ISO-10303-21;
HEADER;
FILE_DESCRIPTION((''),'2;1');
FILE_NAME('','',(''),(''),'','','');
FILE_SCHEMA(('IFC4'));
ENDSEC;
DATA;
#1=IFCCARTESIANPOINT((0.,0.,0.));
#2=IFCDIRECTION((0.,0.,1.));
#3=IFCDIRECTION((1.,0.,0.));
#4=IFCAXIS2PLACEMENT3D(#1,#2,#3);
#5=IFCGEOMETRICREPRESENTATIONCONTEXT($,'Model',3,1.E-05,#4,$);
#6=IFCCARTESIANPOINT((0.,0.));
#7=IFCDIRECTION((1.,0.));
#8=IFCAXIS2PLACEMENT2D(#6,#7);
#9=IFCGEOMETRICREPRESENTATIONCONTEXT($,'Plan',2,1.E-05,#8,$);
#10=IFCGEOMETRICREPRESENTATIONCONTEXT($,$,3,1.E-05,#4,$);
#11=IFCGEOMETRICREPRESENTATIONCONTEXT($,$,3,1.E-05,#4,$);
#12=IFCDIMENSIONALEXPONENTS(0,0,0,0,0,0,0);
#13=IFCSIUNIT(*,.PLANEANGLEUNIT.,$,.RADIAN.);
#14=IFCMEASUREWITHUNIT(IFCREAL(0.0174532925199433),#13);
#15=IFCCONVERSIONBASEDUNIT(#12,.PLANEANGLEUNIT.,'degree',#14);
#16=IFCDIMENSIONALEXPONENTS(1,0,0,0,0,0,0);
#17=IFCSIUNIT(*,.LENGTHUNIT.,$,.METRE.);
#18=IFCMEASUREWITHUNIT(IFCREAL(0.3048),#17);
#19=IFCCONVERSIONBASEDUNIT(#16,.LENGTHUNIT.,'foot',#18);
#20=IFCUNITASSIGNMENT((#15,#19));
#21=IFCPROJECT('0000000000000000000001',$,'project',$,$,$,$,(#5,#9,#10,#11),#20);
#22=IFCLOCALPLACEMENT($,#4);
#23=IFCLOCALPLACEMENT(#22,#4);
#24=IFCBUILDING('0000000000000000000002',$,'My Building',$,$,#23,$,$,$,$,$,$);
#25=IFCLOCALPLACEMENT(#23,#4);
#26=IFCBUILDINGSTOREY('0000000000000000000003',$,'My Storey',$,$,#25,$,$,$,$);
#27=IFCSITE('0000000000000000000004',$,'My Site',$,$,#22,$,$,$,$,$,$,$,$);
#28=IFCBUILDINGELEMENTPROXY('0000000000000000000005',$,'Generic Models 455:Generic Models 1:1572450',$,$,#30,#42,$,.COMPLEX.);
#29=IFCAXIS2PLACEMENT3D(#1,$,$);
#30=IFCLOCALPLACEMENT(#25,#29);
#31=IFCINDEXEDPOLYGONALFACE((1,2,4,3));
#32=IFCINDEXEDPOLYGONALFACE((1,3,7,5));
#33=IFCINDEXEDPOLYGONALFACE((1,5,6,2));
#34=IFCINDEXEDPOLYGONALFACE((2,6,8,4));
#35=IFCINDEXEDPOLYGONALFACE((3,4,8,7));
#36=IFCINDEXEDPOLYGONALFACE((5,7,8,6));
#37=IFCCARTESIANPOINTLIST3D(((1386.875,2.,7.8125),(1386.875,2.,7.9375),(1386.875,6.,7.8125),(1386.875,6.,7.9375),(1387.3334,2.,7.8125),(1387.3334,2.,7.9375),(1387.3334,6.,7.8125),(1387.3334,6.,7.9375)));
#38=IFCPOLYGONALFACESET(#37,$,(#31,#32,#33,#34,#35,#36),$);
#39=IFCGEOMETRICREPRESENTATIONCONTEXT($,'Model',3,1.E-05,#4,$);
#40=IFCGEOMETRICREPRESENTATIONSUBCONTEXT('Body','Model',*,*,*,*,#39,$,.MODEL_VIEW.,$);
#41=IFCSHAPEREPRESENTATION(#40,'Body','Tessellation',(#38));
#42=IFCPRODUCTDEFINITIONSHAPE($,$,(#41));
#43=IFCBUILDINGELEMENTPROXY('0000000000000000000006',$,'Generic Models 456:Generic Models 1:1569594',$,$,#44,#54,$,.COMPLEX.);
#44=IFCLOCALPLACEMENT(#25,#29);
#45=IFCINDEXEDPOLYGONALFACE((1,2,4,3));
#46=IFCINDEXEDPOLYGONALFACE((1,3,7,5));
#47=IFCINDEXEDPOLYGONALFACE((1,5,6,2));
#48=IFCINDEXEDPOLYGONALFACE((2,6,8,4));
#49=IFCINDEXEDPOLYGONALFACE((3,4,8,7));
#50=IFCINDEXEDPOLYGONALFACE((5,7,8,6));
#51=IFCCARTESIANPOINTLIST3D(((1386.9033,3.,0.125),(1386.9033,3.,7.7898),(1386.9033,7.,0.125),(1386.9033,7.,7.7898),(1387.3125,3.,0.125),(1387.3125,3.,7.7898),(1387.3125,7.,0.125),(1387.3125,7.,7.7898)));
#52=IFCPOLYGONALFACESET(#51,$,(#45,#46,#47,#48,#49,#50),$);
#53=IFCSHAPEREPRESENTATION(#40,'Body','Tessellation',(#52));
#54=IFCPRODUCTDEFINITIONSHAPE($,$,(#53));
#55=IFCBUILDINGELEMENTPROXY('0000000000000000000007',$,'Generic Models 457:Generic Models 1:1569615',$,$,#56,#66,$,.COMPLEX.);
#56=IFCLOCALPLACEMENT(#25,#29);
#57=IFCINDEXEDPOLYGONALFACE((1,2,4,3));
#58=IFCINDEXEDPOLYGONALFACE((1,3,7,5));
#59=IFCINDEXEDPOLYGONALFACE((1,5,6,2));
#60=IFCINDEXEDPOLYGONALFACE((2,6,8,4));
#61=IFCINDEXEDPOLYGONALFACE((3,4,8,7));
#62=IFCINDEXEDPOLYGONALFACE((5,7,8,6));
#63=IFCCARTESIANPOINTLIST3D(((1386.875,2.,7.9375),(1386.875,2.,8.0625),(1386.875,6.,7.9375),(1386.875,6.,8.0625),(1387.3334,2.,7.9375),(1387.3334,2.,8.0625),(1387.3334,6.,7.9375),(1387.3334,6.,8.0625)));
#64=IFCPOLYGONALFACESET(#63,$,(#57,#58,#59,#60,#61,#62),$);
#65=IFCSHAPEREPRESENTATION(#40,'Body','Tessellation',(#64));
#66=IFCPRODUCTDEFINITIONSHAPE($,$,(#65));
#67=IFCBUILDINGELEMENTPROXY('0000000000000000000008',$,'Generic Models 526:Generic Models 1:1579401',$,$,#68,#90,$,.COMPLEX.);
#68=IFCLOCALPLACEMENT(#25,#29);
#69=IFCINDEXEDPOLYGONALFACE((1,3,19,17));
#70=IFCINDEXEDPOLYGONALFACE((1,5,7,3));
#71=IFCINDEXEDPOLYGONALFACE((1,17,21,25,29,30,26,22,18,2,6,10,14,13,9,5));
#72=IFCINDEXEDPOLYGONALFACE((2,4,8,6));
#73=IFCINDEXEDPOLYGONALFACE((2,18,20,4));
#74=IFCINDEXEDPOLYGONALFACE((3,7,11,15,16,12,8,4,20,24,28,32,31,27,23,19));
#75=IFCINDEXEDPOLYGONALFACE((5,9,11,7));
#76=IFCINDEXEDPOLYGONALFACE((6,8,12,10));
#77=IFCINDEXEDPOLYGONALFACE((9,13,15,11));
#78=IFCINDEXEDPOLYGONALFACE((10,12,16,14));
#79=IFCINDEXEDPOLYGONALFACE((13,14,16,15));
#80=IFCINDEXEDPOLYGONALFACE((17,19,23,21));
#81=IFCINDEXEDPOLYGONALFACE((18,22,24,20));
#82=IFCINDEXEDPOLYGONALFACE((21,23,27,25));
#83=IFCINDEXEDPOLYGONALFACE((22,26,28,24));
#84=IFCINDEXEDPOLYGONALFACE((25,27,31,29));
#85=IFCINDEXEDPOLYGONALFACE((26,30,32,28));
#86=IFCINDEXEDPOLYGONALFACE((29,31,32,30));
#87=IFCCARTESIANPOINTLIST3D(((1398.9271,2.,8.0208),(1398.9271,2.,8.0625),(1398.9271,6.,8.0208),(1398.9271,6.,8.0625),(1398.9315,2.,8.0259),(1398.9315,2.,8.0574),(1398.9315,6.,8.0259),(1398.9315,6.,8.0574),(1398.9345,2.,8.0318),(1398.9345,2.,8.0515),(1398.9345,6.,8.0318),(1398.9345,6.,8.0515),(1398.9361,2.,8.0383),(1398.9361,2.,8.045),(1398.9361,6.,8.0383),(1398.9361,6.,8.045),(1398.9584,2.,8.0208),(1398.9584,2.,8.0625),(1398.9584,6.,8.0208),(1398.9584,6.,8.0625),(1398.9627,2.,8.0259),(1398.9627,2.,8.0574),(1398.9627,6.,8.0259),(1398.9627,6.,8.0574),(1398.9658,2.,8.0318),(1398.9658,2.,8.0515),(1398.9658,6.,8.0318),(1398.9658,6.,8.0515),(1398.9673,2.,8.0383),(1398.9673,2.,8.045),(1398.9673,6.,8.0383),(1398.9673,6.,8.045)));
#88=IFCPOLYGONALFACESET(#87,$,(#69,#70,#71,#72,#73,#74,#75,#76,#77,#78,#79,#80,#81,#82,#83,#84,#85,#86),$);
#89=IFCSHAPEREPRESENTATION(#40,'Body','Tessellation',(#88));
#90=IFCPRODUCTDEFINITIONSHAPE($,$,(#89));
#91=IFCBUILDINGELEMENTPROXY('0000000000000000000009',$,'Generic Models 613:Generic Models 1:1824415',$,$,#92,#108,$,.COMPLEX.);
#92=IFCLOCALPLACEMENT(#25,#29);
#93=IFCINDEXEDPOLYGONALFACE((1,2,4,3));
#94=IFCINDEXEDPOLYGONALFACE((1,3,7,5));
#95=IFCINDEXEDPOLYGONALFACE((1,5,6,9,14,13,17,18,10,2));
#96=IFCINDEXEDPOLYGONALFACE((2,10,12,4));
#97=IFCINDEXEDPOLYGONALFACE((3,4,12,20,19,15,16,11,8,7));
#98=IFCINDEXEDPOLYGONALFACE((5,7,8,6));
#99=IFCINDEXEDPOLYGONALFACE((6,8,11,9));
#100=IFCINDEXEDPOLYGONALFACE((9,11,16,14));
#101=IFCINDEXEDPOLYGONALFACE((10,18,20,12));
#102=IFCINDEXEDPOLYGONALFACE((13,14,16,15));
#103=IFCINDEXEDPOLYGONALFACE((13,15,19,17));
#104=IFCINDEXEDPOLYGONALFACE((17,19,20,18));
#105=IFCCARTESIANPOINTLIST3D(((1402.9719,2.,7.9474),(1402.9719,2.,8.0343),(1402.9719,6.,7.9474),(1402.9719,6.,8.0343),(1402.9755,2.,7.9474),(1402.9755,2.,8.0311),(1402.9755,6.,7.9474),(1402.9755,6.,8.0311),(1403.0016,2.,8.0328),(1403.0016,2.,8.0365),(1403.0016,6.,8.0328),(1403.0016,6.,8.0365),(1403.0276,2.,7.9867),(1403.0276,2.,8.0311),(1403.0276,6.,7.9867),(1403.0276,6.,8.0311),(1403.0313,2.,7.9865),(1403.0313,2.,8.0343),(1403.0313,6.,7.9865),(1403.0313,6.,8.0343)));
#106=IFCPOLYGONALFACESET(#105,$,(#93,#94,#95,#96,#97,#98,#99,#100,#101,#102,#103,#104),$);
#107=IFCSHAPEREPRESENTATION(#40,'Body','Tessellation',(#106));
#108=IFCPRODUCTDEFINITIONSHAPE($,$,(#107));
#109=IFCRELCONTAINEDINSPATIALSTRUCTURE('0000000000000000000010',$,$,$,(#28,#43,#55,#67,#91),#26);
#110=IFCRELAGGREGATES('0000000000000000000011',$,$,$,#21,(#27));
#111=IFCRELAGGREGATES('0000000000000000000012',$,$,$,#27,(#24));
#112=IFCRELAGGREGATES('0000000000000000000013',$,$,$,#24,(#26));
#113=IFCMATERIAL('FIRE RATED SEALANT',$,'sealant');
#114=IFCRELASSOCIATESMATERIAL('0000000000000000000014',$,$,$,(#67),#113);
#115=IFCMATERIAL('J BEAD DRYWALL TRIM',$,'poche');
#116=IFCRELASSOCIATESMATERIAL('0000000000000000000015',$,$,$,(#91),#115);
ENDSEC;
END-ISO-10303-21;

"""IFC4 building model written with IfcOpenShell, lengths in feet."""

from ifc_helpers import new_model, entity, si_unit, converted_unit, frame, origin_with_axes, origin_2d_with_axis, place, context, subcontext, project, spatial, polyline, line, indexed_curve, outline, extrude, material, element, save


model = new_model("IFC4")

# Units and contexts
model_context_1 = context("Model", 3, precision=1e-05, world=origin_with_axes())
plan_context = context("Plan", 2, precision=1e-05, world=origin_2d_with_axis())
model_context_2 = context("Model", 3, precision=1e-05, world=origin_with_axes())
context_of_model_1 = context(None, 3, precision=1e-05, world=origin_with_axes())
context_of_model_2 = context(None, 3, precision=1e-05, world=origin_with_axes())
body_context = subcontext(model_context_2, "Body", "Model", "MODEL_VIEW")
ifc_project = project(units=[converted_unit("PLANEANGLEUNIT", "degree", entity("IfcReal", 0.0174532925199433), si_unit("PLANEANGLEUNIT", "RADIAN"), dimensions=[0, 0, 0, 0, 0, 0, 0]), converted_unit("LENGTHUNIT", "foot", entity("IfcReal", 0.3048), si_unit("LENGTHUNIT", "METRE"), dimensions=[1, 0, 0, 0, 0, 0, 0])], contexts=[model_context_1, plan_context, context_of_model_1, context_of_model_2])

# Site, building, storey
site_placement = place(None, origin_with_axes())
site = spatial("IfcSite", under=ifc_project, at=site_placement, Name="My Site")
building_placement = place(site_placement, origin_with_axes())
building = spatial("IfcBuilding", under=site, at=building_placement, Name="My Building")
storey_placement = place(building_placement, origin_with_axes())
storey = spatial("IfcBuildingStorey", under=building, at=storey_placement, Name="My Storey")

# Building element proxies
ifc_material_1 = material(Name="FIRE RATED SEALANT", Category="sealant")
proxy_1_placement = place(storey_placement, frame((1386.875, 6.0, 7.8125), z_axis=(0.0, -1.0, 0.0), x_axis=(0.0, 0.0, 1.0)))
element("IfcBuildingElementProxy", 1, at=proxy_1_placement, inside=storey, Name="Generic Models 455:Generic Models 1:1572450", PredefinedType="COMPLEX", context=body_context, shape_type="SweptSolid", body=[
    extrude(outline(polyline([(-0.2292, -0.0625), (0.2292, -0.0625), (0.2292, 0.0625), (-0.2292, 0.0625), (-0.2292, -0.0625)])), frame((0.0625, -0.2292, 0.0), z_axis=(0.0, 0.0, -1.0), x_axis=(0.0, 1.0, 0.0)), (0.0, 0.0, -1.0), 4.0),
])
proxy_2_placement = place(storey_placement, frame((1386.9033, 7.0, 0.125), z_axis=(0.0, -1.0, 0.0), x_axis=(0.0, 0.0, 1.0)))
element("IfcBuildingElementProxy", 2, at=proxy_2_placement, inside=storey, Name="Generic Models 456:Generic Models 1:1569594", PredefinedType="COMPLEX", context=body_context, shape_type="SweptSolid", body=[
    extrude(outline(polyline([(-0.2046, -3.8324), (0.2046, -3.8324), (0.2046, 3.8324), (-0.2046, 3.8324), (-0.2046, -3.8324)])), frame((3.8324, -0.2046, 0.0), z_axis=(0.0, 0.0, -1.0), x_axis=(0.0, 1.0, 0.0)), (0.0, 0.0, -1.0), 4.0),
])
proxy_3_placement = place(storey_placement, frame((1386.875, 6.0, 7.9375), z_axis=(0.0, -1.0, 0.0), x_axis=(0.0, 0.0, 1.0)))
element("IfcBuildingElementProxy", 3, at=proxy_3_placement, inside=storey, Name="Generic Models 457:Generic Models 1:1569615", PredefinedType="COMPLEX", context=body_context, shape_type="SweptSolid", body=[
    extrude(outline(polyline([(-0.2292, -0.0625), (0.2292, -0.0625), (0.2292, 0.0625), (-0.2292, 0.0625), (-0.2292, -0.0625)])), frame((0.0625, -0.2292, 0.0), z_axis=(0.0, 0.0, -1.0), x_axis=(0.0, 1.0, 0.0)), (0.0, 0.0, -1.0), 4.0),
])
proxy_4_placement = place(storey_placement, frame((1398.9271, 6.0, 8.0208), z_axis=(0.0, -1.0, 0.0), x_axis=(0.0, 0.0, 1.0)))
element("IfcBuildingElementProxy", 4, at=proxy_4_placement, inside=storey, material=ifc_material_1, Name="Generic Models 526:Generic Models 1:1579401", PredefinedType="COMPLEX", context=body_context, shape_type="SweptSolid", body=[
    extrude(outline(polyline([(0.0216, 0.0), (0.0223, 0.0066), (0.001, 0.0294), (0.0002, 0.0228), (-0.002, 0.0165), (-0.0057, 0.0109), (-0.0105, 0.0064), (-0.0163, 0.0031), (-0.0228, 0.0012), (-0.0294, 0.0009), (-0.008, -0.0219), (-0.0014, -0.0216), (0.005, -0.0197), (0.0108, -0.0164), (0.0157, -0.0119), (0.0194, -0.0063), (0.0216, 0.0)])), frame((0.0208, -0.0208, 0.0), z_axis=(0.0, 0.0, -1.0), x_axis=(-0.729168, -0.684334, 0.0)), (0.0, 0.0, -1.0), 4.0),
])
ifc_material_2 = material(Name="J BEAD DRYWALL TRIM", Category="poche")
proxy_5_placement = place(storey_placement, frame((1402.9719, 6.0, 7.9474), z_axis=(0.0, -1.0, 0.0), x_axis=(0.0, 0.0, 1.0)))
element("IfcBuildingElementProxy", 5, at=proxy_5_placement, inside=storey, material=ifc_material_2, Name="Generic Models 613:Generic Models 1:1824415", PredefinedType="COMPLEX", context=body_context, shape_type="SweptSolid", body=[
    extrude(outline(indexed_curve([(-0.0243, 0.026), (0.0594, 0.026), (0.0594, 0.0297), (-0.0275, 0.0297), (-0.0296, 0.0), (-0.0275, -0.0297), (0.0203, -0.0297), (0.0201, -0.026), (-0.0243, -0.026), (-0.026, 0.0)], segments=[line(5, 4), line(4, 3), line(3, 2), line(2, 1), line(1, 10), line(10, 9), line(9, 8), line(8, 7), line(7, 6), line(6, 5)], self_intersect=False)), frame((0.0594, -0.0297, 0.0), z_axis=(0.0, 0.0, -1.0), x_axis=(-1.0, 0.0, 0.0)), (0.0, 0.0, -1.0), 4.0),
])

save(model, "model.ifc")
